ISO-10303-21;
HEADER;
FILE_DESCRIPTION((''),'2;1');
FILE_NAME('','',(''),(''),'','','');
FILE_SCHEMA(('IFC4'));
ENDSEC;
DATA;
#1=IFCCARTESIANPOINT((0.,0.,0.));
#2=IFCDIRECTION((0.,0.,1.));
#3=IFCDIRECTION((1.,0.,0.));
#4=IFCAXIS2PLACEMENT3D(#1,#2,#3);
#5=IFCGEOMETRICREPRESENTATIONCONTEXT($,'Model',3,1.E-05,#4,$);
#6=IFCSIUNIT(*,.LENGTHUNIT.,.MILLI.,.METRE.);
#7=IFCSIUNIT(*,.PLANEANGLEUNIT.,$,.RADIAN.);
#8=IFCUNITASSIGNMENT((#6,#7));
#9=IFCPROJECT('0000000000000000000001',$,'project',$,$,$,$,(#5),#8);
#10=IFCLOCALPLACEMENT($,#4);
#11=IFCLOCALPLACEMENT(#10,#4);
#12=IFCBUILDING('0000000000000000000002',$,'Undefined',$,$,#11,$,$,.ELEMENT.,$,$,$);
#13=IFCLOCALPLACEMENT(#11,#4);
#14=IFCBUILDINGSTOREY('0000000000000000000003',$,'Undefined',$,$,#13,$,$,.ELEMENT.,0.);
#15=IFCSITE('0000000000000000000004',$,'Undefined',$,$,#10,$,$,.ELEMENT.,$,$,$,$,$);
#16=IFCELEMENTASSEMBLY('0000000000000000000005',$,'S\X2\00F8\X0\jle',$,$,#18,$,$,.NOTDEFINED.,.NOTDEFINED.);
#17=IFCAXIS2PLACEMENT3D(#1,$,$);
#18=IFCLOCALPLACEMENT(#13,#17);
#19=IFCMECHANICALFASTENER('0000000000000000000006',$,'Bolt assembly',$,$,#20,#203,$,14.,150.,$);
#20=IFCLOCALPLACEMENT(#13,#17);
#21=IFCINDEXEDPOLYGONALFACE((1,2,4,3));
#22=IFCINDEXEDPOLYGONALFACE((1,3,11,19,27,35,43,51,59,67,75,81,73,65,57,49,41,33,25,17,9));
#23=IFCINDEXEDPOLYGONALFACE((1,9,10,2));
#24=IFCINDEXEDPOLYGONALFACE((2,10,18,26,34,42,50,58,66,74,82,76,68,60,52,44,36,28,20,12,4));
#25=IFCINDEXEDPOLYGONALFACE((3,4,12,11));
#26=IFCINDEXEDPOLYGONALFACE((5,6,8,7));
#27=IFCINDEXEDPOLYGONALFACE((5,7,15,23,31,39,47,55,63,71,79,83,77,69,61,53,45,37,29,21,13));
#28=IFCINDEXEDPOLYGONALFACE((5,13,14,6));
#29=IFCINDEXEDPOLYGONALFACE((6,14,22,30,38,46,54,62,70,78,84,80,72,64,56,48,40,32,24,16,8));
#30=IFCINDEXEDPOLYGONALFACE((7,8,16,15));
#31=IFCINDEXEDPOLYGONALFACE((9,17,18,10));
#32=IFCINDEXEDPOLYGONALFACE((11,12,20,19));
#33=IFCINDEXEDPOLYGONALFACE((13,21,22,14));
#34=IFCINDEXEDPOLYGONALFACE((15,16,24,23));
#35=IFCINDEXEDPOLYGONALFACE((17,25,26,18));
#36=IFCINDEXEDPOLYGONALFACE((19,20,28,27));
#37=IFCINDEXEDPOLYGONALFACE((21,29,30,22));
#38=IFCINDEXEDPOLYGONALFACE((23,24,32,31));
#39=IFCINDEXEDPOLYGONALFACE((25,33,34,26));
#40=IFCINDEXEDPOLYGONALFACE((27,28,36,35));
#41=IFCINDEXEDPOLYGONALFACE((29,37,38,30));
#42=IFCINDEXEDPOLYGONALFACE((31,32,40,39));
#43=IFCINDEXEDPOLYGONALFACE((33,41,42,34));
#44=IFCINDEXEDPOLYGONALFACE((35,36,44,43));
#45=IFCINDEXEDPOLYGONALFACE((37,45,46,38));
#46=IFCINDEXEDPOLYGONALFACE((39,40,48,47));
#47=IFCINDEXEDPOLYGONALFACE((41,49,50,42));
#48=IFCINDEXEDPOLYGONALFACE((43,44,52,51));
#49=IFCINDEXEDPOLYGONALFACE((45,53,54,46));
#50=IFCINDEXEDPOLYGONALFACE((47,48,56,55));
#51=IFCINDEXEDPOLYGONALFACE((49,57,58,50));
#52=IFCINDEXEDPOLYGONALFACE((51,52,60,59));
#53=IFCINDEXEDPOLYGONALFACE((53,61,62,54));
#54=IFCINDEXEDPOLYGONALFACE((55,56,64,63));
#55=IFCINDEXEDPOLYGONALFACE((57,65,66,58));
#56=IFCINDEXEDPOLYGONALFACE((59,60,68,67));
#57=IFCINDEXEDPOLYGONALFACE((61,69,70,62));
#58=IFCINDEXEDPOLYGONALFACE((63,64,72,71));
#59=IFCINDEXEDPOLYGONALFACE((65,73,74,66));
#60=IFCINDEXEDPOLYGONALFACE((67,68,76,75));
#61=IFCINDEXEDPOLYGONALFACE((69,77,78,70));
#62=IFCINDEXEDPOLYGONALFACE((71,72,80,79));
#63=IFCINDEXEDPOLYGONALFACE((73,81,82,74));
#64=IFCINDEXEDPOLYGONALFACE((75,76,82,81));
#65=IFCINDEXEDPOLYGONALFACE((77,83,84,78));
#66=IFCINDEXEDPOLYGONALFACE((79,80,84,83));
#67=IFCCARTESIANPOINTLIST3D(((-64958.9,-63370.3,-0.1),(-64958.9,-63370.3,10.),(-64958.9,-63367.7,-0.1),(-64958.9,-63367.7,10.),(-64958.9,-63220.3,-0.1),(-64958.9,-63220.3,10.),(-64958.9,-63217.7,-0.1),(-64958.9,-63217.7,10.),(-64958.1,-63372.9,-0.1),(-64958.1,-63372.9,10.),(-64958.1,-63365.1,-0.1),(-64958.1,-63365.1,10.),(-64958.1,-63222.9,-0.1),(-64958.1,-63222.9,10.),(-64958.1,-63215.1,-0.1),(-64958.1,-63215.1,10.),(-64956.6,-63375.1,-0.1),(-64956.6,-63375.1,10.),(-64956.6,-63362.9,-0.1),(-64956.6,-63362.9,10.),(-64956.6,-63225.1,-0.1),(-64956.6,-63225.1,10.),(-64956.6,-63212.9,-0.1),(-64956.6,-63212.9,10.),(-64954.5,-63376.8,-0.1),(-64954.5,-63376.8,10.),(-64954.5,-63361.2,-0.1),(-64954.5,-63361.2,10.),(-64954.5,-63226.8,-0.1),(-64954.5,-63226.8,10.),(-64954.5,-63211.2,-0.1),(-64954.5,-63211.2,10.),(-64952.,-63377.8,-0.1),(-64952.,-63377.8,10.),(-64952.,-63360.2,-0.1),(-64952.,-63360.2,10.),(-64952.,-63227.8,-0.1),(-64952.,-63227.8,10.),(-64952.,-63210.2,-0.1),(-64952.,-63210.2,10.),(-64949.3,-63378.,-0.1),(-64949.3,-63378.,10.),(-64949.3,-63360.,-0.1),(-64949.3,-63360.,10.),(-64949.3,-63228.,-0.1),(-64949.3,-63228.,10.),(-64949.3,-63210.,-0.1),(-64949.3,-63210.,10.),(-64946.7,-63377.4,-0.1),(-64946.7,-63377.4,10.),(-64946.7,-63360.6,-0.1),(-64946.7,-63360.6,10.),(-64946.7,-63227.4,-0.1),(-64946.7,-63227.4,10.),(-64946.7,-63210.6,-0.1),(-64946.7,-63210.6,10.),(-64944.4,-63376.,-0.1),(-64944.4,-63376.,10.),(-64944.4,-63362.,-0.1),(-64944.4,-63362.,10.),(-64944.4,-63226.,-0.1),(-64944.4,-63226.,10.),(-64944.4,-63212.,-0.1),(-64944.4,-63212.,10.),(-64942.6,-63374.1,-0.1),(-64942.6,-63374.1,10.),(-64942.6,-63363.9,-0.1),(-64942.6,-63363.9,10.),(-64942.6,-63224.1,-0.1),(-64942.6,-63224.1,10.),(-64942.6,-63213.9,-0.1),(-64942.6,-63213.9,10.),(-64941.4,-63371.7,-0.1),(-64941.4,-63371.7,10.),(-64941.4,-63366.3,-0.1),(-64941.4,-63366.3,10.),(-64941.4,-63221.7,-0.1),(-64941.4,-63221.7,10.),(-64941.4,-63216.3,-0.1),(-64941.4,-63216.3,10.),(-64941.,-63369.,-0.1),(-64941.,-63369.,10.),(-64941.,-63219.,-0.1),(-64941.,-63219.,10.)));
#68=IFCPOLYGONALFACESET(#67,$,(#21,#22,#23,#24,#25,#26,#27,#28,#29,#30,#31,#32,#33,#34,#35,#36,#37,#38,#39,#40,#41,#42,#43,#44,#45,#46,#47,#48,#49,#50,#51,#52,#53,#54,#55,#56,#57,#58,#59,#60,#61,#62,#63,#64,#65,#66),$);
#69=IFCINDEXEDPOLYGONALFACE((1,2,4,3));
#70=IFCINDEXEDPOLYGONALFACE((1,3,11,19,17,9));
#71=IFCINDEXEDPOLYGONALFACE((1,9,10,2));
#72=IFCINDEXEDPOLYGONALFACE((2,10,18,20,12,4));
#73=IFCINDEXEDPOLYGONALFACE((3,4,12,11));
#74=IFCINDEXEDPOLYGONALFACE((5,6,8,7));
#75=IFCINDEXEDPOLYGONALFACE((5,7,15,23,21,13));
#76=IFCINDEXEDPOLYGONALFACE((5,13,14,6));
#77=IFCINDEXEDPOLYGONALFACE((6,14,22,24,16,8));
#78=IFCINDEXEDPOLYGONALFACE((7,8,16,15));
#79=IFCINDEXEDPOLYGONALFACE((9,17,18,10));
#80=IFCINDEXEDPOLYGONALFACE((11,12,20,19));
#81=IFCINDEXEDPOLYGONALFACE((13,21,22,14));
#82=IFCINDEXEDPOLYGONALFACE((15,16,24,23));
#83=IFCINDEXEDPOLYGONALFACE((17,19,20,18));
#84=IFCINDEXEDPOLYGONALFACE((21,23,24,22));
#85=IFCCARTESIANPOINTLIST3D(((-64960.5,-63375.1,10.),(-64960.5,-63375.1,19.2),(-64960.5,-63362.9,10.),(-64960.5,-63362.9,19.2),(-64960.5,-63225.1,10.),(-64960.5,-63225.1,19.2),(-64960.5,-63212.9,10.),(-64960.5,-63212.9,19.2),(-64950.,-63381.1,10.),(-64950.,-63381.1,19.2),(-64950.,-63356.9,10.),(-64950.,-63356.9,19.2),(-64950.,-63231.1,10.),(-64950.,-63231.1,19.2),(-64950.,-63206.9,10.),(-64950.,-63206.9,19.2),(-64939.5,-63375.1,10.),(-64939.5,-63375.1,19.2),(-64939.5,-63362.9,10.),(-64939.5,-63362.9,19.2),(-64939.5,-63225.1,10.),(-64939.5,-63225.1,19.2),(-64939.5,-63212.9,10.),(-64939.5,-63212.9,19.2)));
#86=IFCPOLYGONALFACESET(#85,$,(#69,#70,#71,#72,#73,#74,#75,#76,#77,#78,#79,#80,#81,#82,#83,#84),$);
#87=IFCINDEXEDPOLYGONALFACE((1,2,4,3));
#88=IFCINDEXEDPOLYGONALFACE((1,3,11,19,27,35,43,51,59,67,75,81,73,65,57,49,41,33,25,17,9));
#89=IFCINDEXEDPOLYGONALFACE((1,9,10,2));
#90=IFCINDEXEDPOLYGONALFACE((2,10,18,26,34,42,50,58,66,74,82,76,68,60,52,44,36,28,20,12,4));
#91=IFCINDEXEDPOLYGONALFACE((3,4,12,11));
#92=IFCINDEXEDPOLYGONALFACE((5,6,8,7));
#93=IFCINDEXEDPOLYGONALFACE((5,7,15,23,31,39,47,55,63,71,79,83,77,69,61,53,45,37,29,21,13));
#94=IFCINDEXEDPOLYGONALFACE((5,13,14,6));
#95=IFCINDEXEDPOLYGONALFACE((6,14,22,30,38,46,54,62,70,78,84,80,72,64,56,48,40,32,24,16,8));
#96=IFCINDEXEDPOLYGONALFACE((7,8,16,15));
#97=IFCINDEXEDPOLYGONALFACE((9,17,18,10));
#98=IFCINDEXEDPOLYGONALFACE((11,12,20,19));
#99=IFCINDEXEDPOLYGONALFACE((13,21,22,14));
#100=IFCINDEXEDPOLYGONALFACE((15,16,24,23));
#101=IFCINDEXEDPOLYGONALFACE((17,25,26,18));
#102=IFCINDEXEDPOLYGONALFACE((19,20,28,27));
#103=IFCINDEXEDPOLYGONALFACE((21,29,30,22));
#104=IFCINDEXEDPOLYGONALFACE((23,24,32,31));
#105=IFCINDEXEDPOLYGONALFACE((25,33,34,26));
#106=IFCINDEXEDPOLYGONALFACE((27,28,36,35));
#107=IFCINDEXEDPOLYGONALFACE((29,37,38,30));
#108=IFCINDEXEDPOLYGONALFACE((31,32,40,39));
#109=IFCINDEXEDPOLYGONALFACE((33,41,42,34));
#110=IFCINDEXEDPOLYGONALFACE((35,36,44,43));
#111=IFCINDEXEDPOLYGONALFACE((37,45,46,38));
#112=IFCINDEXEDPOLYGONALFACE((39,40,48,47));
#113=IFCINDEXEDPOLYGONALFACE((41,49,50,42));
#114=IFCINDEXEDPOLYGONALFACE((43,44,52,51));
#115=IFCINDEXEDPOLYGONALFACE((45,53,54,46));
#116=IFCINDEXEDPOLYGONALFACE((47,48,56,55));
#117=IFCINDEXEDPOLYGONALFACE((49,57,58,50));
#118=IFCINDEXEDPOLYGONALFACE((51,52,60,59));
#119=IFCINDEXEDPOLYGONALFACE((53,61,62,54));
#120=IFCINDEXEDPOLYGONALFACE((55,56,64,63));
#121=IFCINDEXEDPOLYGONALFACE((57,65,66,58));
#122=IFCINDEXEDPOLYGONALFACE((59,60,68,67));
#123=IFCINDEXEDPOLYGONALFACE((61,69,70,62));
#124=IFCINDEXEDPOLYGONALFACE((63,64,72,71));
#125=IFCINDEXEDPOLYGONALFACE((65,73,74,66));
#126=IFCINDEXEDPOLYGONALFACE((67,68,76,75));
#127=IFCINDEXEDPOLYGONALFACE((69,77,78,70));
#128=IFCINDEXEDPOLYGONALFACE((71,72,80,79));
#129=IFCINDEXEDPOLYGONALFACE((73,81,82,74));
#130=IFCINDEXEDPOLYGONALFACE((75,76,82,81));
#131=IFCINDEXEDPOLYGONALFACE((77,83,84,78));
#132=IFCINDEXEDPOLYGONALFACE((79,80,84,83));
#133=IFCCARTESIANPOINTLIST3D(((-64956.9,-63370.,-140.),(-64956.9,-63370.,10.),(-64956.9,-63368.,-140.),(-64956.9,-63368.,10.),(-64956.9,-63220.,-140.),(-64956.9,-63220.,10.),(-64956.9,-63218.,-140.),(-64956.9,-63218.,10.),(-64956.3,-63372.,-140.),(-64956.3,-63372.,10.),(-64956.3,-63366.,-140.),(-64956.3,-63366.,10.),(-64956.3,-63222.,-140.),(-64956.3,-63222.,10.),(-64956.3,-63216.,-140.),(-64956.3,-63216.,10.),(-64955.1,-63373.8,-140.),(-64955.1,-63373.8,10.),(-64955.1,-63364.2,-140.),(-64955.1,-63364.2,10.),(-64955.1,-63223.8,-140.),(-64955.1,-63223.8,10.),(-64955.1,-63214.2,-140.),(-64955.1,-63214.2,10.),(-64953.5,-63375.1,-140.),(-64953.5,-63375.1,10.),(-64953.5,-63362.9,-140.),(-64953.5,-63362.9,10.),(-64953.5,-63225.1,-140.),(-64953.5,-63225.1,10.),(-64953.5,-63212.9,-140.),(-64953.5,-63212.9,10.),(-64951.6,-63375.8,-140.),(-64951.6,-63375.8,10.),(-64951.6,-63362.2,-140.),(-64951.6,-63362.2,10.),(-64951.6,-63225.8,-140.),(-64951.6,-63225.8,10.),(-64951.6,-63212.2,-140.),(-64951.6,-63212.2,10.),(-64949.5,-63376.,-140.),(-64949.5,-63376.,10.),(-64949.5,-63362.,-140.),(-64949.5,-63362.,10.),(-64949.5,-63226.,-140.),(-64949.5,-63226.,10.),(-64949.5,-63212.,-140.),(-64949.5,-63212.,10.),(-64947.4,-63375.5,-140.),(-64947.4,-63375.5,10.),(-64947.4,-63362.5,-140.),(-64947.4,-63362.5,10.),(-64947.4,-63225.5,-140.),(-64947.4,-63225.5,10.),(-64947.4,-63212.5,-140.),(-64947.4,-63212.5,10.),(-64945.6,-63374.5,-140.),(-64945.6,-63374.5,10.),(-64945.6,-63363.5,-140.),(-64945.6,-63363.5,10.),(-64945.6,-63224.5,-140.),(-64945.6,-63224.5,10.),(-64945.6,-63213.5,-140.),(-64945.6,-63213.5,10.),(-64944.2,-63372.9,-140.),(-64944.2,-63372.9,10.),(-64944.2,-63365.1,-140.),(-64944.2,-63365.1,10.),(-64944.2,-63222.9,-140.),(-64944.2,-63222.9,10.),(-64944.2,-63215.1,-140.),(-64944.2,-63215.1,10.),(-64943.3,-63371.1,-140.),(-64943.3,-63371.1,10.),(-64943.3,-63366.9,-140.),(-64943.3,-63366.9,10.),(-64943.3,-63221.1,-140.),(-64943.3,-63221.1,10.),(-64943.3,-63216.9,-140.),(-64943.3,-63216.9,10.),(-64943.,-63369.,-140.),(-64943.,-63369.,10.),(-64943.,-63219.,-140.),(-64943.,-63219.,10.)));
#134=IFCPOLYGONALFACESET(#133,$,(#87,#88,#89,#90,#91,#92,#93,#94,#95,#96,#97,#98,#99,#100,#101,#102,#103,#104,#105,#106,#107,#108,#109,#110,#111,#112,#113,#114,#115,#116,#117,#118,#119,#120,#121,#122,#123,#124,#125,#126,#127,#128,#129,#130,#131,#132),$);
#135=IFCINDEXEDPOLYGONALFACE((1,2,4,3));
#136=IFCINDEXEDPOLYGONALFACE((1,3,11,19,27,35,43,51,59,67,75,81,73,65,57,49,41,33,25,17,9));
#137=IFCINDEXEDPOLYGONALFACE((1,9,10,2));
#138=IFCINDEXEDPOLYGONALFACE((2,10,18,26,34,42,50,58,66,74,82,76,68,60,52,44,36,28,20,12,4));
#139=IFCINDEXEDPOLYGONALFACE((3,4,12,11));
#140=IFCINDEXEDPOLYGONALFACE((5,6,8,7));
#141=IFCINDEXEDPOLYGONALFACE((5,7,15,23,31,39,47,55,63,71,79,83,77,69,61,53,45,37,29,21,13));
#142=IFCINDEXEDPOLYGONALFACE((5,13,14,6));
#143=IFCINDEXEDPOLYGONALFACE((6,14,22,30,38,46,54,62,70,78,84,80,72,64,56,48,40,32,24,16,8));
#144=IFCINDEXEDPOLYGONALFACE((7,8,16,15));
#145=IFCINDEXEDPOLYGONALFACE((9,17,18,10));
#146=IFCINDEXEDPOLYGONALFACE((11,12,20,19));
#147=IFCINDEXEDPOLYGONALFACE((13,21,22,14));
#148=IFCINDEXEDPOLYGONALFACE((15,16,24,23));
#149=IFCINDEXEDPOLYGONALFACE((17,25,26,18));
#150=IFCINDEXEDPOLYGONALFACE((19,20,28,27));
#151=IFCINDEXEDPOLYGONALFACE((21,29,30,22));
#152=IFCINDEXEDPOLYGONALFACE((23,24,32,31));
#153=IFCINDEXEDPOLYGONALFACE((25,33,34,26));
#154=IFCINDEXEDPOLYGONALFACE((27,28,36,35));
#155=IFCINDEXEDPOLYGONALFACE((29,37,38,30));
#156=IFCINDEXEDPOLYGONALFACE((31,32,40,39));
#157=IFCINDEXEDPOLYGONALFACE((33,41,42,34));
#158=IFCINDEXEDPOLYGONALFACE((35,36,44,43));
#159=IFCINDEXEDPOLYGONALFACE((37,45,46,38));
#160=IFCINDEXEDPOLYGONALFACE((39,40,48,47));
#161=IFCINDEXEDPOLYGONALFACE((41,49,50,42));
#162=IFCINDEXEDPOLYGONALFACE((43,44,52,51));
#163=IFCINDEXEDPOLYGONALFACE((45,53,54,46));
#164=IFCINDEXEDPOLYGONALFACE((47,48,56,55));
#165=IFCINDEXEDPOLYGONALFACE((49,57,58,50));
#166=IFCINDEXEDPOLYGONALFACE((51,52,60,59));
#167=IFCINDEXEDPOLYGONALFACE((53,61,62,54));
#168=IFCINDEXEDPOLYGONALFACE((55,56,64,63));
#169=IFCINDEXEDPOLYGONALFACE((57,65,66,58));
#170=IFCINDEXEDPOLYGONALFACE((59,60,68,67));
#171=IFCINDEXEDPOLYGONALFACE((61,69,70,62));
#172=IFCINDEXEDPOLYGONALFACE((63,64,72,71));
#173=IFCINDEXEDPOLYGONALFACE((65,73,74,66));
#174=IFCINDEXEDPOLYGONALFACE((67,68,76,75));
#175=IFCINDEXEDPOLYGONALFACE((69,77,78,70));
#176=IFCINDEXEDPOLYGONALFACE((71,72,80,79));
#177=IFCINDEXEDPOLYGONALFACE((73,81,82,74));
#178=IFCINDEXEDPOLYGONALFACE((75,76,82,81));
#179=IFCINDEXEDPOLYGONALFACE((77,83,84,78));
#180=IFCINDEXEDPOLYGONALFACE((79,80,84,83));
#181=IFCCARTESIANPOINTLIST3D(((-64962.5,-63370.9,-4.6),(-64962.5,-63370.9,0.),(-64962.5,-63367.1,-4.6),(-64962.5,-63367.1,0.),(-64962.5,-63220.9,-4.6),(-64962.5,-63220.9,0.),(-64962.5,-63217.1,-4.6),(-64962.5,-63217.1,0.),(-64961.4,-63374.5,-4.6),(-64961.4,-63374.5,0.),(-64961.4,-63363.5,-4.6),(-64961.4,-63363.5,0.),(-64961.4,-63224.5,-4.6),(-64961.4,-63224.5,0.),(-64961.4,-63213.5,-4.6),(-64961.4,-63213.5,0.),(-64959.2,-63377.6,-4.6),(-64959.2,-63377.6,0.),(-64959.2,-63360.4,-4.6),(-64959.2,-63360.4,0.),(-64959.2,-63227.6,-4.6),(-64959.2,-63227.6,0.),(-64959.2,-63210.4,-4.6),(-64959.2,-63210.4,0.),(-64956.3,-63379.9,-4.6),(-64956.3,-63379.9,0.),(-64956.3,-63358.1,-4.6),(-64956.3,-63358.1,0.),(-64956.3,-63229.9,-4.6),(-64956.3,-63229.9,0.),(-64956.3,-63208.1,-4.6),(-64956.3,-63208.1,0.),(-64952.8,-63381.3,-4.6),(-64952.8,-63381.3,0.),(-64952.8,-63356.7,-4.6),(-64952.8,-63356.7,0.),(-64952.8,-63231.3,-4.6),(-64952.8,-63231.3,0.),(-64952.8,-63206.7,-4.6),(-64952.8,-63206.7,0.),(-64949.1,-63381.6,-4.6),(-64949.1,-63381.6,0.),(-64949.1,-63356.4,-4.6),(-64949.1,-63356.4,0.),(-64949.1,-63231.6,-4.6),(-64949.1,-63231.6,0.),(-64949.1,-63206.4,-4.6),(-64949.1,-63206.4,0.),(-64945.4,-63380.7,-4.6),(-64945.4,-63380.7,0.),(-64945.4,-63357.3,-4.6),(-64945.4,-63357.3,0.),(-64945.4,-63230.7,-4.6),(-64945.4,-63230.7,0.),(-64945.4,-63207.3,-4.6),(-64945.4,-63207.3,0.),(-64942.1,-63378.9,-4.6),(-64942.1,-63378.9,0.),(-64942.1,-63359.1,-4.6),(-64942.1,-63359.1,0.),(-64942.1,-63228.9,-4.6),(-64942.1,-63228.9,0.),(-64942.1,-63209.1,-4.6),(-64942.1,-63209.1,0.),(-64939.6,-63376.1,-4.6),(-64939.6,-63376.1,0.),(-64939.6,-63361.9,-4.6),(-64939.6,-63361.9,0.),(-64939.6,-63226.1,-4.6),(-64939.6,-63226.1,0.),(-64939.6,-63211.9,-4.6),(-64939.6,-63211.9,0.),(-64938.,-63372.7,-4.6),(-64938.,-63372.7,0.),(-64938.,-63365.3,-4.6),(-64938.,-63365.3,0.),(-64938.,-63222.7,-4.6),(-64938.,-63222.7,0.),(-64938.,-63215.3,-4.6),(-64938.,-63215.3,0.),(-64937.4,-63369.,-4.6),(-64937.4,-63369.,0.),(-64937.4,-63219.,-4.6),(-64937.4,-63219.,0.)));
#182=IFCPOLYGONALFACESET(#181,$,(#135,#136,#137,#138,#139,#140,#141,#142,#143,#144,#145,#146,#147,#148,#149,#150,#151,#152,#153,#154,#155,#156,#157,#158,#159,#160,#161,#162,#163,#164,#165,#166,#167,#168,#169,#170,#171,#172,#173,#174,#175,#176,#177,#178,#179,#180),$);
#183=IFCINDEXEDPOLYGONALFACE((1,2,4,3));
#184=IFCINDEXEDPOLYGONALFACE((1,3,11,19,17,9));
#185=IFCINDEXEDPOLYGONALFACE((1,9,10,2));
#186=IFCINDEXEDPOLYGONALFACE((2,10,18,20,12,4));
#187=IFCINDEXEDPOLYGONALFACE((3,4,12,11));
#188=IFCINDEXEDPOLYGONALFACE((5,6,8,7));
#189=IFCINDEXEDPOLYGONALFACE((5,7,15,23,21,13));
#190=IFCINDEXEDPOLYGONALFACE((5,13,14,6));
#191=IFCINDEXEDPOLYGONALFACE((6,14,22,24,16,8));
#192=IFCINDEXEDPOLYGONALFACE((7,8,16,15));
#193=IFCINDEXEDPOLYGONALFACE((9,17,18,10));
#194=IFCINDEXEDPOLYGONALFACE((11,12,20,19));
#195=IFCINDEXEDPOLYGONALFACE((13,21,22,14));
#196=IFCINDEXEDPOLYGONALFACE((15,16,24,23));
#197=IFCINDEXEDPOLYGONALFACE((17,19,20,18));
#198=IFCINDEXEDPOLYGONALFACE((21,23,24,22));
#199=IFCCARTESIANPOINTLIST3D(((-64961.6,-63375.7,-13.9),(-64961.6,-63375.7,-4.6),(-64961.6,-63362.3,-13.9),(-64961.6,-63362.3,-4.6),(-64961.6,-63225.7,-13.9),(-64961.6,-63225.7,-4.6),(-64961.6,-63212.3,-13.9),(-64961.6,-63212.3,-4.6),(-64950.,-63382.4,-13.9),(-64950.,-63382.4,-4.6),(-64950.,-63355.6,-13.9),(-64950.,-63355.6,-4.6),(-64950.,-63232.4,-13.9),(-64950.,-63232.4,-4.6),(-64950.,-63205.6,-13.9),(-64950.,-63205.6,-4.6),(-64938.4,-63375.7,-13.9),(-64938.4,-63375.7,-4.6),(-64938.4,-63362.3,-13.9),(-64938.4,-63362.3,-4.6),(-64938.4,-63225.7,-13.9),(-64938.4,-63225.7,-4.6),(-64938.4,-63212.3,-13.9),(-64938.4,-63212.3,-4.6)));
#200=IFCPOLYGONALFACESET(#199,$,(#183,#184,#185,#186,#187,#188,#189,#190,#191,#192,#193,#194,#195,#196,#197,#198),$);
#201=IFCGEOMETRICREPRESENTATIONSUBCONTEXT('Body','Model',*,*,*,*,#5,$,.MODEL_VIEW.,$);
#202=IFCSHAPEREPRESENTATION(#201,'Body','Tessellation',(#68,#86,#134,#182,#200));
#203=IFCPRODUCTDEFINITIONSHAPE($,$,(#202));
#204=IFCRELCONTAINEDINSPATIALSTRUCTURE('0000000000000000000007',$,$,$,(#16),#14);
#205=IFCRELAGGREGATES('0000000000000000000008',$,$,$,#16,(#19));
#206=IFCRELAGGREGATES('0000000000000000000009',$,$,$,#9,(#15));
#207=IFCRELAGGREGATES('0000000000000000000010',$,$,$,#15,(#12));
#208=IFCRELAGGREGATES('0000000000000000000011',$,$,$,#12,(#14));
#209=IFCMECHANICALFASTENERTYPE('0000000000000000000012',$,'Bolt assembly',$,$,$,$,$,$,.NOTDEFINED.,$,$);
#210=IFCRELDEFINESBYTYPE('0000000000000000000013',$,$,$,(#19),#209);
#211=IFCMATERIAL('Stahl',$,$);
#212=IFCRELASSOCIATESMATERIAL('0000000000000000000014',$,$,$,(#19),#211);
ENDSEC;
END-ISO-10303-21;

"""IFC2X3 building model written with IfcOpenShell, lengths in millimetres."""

from ifc_helpers import new_model, si_unit, frame, origin_with_axes, origin_2d_with_axis, place, context, subcontext, project, spatial, polyline, circle, outline, extrude, source, transform, mapped, material, type_object, element, aggregate, save


model = new_model("IFC2X3")

# Units and contexts
model_context = context("Model", 3, precision=1e-05, world=origin_with_axes())
body_context = subcontext(model_context, "Body", "Model", "MODEL_VIEW")
ifc_project = project(units=[si_unit("LENGTHUNIT", "METRE", prefix="MILLI"), si_unit("PLANEANGLEUNIT", "RADIAN")], contexts=[model_context])

# Site, building, storey
site_placement = place(None, origin_with_axes())
site = spatial("IfcSite", under=ifc_project, at=site_placement, Name="Undefined", CompositionType="ELEMENT")
building_placement = place(site_placement, origin_with_axes())
building = spatial("IfcBuilding", under=site, at=building_placement, Name="Undefined", CompositionType="ELEMENT")
storey_placement = place(building_placement, origin_with_axes())
storey = spatial("IfcBuildingStorey", under=building, at=storey_placement, Name="Undefined", CompositionType="ELEMENT", Elevation=0.0)

# Element assembly
assembly_1_placement = place(storey_placement, origin_with_axes())
assembly_1 = element("IfcElementAssembly", 1, at=assembly_1_placement, inside=storey, Name="Søjle", AssemblyPlace="NOTDEFINED", PredefinedType="NOTDEFINED")

# Mechanical fastener
mechanical_fastener_type = type_object("IfcMechanicalFastenerType", Name="Bolt assembly")
ifc_material_1 = material(Name="Stahl")
shared_shape_1 = source(origin_with_axes(), body_context, "Body", "SweptSolid", [
    extrude(circle(Radius=9.0, at=origin_2d_with_axis()), frame((0.0, 0.0, 0.0), z_axis=(0.0, 1.0, 0.0), x_axis=(1.0, 0.0, 0.0)), (0.0, 0.0, 1.0), 10.1),
    extrude(outline(polyline([(10.5, -6.1), (10.5, 6.1), (0.0, 12.1), (-10.5, 6.1), (-10.5, -6.1), (0.0, -12.1), (10.5, -6.1)])), frame((0.0, -9.2, 0.0), z_axis=(0.0, 1.0, 0.0), x_axis=(1.0, 0.0, 0.0)), (0.0, 0.0, 1.0), 9.2),
    extrude(circle(Radius=7.0, at=origin_2d_with_axis()), frame((0.0, 0.0, 0.0), z_axis=(0.0, 1.0, 0.0), x_axis=(1.0, 0.0, 0.0)), (0.0, 0.0, 1.0), 150.0),
    extrude(circle(Radius=12.6, at=origin_2d_with_axis()), frame((0.0, 10.0, 0.0), z_axis=(0.0, 1.0, 0.0), x_axis=(1.0, 0.0, 0.0)), (0.0, 0.0, 1.0), 4.6),
    extrude(outline(polyline([(11.6, -6.7), (11.6, 6.7), (0.0, 13.4), (-11.6, 6.7), (-11.6, -6.7), (0.0, -13.4), (11.6, -6.7)])), frame((0.0, 14.6, 0.0), z_axis=(0.0, 1.0, 0.0), x_axis=(1.0, 0.0, 0.0)), (0.0, 0.0, 1.0), 9.2),
])
mechanical_fastener_1_placement = place(assembly_1_placement, frame((-64950.0, -63294.0, 10.0), z_axis=(0.0, 1.0, 0.0), x_axis=(1.0, 0.0, 0.0)))
mechanical_fastener_1 = element("IfcMechanicalFastener", 2, at=mechanical_fastener_1_placement, type_object=mechanical_fastener_type, material=ifc_material_1, Name="Bolt assembly", NominalDiameter=14.0, NominalLength=150.0, context=body_context, shape_type="MappedRepresentation", body=[
    mapped(shared_shape_1, transform((0.0, 0.0, -75.0))),
    mapped(shared_shape_1, transform((0.0, 0.0, 75.0))),
])
aggregate(assembly_1, [mechanical_fastener_1])

save(model, "model.ifc")
